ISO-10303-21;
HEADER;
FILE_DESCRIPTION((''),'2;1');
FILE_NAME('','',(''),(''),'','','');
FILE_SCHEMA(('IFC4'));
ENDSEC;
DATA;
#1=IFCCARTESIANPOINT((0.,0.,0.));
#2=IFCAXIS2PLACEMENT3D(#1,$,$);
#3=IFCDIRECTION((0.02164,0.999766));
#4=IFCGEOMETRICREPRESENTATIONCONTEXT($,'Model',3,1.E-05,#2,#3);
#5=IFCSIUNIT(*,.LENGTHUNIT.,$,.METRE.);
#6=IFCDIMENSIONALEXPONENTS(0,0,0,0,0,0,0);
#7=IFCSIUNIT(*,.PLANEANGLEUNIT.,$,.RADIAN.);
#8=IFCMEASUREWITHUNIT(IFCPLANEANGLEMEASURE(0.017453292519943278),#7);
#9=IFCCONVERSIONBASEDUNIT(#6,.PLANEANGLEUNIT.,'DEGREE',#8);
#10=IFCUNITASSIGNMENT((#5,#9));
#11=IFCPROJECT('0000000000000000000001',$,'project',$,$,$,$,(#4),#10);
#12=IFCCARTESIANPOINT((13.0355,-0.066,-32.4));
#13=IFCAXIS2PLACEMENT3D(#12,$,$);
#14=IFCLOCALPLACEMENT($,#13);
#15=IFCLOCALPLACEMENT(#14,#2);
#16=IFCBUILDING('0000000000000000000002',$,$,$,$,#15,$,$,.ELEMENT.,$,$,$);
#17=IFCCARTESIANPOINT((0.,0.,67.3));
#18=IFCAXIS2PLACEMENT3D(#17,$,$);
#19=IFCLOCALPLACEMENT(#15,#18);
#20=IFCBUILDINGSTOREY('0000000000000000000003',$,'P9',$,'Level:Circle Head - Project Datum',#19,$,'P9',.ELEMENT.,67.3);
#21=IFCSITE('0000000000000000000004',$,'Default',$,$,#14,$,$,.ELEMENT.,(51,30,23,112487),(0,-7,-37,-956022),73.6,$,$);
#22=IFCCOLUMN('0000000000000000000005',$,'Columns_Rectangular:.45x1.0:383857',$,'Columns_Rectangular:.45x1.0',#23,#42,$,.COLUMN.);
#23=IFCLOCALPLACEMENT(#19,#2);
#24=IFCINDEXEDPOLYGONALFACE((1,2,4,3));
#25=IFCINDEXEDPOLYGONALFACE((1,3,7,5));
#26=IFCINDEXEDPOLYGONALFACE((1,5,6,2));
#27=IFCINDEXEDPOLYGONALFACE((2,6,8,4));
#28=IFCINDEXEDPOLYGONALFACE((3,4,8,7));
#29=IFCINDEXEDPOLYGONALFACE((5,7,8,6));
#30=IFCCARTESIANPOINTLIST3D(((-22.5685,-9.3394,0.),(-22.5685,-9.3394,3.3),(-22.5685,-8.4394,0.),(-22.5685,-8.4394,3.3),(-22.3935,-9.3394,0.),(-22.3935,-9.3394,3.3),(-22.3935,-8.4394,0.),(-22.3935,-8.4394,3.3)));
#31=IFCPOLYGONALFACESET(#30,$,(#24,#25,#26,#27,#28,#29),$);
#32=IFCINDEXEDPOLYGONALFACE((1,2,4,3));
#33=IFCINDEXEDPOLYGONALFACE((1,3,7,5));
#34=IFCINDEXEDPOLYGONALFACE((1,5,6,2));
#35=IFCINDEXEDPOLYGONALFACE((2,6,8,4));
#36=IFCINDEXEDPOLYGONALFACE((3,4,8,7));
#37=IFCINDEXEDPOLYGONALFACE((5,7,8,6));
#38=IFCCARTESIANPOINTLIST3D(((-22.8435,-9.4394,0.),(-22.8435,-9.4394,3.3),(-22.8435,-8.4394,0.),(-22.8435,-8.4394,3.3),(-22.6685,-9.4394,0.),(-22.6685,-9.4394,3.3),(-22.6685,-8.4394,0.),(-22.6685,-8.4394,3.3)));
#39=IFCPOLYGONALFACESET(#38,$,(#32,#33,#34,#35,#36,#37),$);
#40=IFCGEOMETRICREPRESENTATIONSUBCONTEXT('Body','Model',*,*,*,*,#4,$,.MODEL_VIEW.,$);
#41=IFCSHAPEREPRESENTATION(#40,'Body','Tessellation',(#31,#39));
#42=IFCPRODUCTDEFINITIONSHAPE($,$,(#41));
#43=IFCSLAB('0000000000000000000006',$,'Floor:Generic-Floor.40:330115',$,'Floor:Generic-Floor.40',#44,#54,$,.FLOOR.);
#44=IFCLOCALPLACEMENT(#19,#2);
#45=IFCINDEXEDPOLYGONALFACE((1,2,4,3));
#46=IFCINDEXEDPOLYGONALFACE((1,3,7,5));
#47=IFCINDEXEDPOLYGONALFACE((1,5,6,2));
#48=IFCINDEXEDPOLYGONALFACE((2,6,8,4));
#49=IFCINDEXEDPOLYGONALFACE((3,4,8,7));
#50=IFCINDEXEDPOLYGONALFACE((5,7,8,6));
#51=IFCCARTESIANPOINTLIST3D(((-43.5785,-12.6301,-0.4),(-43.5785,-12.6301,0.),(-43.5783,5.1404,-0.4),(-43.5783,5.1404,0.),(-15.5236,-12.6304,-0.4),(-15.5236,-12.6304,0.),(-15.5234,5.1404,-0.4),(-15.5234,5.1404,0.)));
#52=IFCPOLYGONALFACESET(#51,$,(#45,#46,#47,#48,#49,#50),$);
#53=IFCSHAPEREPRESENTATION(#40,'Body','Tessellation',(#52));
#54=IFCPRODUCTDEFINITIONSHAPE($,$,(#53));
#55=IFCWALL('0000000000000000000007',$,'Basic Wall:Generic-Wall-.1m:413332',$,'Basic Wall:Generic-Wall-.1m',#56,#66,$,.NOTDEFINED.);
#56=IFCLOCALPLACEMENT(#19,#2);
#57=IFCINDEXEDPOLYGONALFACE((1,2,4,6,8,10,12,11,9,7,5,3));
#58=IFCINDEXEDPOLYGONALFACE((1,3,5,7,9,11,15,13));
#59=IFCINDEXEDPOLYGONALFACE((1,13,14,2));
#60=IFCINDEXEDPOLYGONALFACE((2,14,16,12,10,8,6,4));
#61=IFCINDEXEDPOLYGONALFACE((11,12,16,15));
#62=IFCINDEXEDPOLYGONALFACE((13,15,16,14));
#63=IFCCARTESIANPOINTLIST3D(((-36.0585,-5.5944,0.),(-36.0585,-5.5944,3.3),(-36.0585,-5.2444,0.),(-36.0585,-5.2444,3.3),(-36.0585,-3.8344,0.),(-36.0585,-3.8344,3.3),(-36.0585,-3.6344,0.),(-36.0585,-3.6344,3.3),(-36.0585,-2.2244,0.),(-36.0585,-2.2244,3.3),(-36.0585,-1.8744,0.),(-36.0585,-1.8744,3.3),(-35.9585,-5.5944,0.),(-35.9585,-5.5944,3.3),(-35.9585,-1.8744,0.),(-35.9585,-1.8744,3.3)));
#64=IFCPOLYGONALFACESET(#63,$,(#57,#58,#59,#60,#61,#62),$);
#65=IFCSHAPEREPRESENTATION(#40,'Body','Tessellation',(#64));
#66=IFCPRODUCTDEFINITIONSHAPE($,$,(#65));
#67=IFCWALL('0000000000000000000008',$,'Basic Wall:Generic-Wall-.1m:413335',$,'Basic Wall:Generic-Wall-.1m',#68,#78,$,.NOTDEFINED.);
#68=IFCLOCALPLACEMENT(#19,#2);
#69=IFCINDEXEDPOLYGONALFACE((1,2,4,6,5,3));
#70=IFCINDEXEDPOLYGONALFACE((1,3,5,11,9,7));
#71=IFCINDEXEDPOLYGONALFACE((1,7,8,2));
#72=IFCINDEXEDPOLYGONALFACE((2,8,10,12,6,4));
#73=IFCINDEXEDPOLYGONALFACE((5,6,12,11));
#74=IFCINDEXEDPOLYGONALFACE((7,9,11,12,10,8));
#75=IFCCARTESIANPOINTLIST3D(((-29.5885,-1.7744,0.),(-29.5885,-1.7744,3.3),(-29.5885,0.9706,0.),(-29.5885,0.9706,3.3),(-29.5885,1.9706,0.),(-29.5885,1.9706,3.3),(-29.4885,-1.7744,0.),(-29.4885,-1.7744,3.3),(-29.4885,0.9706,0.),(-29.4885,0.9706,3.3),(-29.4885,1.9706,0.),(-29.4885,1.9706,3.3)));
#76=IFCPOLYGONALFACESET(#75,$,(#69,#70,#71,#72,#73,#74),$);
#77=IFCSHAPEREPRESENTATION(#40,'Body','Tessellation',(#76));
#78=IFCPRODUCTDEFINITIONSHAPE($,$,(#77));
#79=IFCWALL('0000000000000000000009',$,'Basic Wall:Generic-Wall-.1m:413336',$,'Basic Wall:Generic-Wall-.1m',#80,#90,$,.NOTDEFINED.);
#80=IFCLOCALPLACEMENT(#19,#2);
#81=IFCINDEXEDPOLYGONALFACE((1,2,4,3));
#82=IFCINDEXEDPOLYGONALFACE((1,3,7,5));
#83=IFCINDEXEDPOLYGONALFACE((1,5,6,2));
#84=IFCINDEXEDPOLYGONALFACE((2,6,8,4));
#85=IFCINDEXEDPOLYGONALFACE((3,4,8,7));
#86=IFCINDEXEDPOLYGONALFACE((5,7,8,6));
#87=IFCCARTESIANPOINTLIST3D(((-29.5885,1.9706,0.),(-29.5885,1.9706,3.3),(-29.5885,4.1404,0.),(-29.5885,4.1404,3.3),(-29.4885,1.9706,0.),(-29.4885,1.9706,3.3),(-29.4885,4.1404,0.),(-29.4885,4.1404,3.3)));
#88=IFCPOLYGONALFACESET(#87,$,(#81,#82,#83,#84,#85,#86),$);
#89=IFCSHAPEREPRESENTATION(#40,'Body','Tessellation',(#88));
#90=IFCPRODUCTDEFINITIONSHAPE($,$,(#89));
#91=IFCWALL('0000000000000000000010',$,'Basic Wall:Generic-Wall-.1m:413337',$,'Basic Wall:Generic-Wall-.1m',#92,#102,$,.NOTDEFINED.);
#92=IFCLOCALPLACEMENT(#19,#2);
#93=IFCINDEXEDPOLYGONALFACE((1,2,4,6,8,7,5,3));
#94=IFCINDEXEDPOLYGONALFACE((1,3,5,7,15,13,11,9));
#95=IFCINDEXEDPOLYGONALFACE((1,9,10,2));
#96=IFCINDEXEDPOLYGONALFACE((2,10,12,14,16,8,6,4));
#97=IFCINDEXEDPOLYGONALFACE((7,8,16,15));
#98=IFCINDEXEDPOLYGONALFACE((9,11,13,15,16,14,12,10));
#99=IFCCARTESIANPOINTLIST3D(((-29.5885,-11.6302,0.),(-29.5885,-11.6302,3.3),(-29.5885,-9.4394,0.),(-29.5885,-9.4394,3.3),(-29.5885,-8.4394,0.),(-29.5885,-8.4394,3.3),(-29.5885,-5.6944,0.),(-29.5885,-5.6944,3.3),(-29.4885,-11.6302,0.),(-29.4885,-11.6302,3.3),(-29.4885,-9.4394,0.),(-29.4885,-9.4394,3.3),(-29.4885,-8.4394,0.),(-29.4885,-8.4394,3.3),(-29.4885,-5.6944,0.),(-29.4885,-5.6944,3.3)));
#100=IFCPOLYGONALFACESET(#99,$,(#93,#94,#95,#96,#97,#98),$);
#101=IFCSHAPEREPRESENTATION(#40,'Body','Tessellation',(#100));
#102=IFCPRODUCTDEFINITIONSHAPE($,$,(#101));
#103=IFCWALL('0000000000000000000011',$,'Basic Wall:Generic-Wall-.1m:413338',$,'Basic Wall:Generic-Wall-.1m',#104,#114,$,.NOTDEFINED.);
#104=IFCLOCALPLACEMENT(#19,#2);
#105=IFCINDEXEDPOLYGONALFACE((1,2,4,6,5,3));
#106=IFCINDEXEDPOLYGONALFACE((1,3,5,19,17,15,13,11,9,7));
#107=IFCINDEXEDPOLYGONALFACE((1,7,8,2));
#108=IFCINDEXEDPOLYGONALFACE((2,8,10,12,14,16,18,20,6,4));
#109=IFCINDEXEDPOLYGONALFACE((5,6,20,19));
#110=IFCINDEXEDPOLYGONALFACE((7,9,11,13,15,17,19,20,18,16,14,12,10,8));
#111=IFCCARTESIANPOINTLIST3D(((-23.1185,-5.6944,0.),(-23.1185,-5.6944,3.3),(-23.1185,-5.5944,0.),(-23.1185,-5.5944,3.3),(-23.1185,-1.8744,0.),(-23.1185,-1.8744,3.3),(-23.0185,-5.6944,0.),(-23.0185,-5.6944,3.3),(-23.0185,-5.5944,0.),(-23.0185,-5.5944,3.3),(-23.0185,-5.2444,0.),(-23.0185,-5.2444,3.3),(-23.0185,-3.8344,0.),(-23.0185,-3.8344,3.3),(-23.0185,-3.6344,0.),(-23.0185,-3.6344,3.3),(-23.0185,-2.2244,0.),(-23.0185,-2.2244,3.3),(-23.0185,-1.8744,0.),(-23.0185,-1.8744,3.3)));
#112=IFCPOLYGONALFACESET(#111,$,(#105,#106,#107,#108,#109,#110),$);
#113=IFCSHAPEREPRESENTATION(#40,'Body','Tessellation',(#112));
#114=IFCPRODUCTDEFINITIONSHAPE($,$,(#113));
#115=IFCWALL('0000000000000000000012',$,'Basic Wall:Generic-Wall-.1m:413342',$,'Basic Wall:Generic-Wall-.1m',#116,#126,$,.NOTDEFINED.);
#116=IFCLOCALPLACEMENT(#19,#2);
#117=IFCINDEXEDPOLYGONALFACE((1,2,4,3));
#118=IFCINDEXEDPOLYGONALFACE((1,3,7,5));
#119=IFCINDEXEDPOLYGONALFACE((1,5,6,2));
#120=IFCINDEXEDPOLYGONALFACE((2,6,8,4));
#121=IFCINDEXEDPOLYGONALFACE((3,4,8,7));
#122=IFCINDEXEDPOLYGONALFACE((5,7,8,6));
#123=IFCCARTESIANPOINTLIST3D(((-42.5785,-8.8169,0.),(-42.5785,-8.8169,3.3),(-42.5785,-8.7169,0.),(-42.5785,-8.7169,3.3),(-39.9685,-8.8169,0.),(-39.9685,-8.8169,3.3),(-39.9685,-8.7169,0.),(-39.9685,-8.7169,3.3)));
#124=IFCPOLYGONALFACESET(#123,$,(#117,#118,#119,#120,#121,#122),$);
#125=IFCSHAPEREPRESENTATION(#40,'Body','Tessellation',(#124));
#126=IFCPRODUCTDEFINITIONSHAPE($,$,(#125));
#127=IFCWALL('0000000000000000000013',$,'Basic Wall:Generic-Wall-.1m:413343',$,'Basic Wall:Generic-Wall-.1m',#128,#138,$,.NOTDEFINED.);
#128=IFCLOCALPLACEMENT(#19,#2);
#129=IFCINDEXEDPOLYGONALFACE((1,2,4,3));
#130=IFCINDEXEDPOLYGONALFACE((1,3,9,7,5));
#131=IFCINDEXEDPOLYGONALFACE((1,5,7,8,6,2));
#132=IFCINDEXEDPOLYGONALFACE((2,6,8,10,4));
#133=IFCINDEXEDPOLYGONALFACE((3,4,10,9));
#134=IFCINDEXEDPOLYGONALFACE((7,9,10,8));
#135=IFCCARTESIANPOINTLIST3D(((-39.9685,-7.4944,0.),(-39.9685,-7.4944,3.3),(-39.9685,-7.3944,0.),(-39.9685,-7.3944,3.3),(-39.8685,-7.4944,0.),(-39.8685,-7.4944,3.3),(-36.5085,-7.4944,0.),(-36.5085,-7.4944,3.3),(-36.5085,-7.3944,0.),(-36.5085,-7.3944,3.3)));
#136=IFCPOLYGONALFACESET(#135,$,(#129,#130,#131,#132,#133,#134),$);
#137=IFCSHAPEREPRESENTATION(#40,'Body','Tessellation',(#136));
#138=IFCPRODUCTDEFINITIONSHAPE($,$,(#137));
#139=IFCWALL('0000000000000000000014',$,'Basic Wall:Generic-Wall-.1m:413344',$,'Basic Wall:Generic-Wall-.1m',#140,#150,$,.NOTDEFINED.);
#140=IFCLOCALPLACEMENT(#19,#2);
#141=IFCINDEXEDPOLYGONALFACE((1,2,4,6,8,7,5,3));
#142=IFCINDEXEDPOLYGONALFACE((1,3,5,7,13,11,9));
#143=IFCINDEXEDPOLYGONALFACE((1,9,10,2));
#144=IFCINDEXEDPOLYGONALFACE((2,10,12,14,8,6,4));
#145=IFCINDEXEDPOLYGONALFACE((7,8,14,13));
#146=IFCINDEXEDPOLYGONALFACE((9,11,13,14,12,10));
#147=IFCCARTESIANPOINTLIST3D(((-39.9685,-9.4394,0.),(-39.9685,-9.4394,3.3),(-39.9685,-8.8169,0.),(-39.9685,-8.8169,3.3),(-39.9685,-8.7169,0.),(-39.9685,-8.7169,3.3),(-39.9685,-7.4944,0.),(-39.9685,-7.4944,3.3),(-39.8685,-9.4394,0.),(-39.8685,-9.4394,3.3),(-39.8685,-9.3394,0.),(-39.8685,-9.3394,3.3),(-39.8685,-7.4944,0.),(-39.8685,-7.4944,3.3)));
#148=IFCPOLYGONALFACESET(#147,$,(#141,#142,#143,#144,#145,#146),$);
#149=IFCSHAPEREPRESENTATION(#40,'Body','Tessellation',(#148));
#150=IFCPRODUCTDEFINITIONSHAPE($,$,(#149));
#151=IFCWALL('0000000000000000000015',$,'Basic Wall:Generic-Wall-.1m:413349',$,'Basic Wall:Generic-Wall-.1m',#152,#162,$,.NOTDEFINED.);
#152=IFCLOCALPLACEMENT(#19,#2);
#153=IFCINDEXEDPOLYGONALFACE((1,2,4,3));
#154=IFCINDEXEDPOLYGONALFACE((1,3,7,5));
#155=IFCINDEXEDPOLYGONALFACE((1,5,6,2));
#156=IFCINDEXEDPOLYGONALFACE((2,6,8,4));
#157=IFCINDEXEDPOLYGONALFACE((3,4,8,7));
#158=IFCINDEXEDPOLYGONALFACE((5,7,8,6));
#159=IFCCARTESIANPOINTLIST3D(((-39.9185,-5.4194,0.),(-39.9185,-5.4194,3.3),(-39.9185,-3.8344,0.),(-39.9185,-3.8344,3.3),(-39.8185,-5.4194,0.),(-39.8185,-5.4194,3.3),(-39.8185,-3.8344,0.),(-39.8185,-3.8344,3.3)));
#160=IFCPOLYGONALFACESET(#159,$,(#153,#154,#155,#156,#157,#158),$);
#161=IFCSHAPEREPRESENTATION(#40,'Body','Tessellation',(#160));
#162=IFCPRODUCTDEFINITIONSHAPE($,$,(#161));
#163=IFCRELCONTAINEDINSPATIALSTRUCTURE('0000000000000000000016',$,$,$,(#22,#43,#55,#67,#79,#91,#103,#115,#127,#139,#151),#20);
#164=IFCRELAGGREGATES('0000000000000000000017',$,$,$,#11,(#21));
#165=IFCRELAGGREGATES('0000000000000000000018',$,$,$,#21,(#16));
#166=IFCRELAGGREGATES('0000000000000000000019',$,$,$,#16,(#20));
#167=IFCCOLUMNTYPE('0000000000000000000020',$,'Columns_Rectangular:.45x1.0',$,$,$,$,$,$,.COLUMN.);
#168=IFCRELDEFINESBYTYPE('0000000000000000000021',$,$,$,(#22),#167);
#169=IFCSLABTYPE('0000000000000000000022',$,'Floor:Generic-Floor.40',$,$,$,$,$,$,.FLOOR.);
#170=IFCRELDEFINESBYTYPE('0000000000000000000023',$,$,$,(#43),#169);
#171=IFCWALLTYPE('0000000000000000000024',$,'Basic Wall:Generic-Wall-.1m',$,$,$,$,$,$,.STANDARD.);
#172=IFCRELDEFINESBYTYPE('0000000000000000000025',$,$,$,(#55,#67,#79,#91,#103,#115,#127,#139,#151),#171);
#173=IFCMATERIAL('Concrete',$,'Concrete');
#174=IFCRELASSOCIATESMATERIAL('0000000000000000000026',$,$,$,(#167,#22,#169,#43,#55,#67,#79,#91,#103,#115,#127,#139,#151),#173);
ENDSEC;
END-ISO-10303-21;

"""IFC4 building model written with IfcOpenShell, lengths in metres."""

from ifc_helpers import new_model, entity, si_unit, converted_unit, direction, frame, origin, place, context, subcontext, project, spatial, indexed_curve, outline, extrude, source, transform, mapped, material, type_object, type_shapes, element, save


model = new_model("IFC4")

# Units and contexts
model_context = context("Model", 3, precision=1e-05, world=origin(), true_north=direction((0.02164, 0.999766)))
body_context = subcontext(model_context, "Body", "Model", "MODEL_VIEW")
ifc_project = project(units=[si_unit("LENGTHUNIT", "METRE"), converted_unit("PLANEANGLEUNIT", "DEGREE", entity("IfcPlaneAngleMeasure", 0.017453292519943278), si_unit("PLANEANGLEUNIT", "RADIAN"), dimensions=[0, 0, 0, 0, 0, 0, 0])], contexts=[model_context])

# Site, building, storey
site_placement = place(None, frame((13.0355, -0.066, -32.4)))
site = spatial("IfcSite", under=ifc_project, at=site_placement, Name="Default", CompositionType="ELEMENT", RefLatitude=(51, 30, 23, 112487), RefLongitude=(0, -7, -37, -956022), RefElevation=73.6)
building_placement = place(site_placement, origin())
building = spatial("IfcBuilding", under=site, at=building_placement, CompositionType="ELEMENT")
storey_placement = place(building_placement, frame((0.0, 0.0, 67.3)))
storey = spatial("IfcBuildingStorey", under=building, at=storey_placement, Name="P9", ObjectType="Level:Circle Head - Project Datum", LongName="P9", CompositionType="ELEMENT", Elevation=67.3)

# Column
ifc_material = material(Name="Concrete", Category="Concrete")
column_type = type_object("IfcColumnType", Name="Columns_Rectangular:.45x1.0", PredefinedType="COLUMN", material=ifc_material)
shared_shape = source(origin(), body_context, "Body", "SweptSolid", [
    extrude(outline(indexed_curve([(-0.45, -0.0875), (0.45, -0.0875), (0.45, 0.0875), (-0.45, 0.0875), (-0.45, -0.0875)], self_intersect=False)), frame((-22.481, -8.8894, 67.3), z_axis=(0.0, 0.0, 1.0), x_axis=(0.0, -1.0, 0.0)), (0.0, 0.0, 1.0), 3.3),
    extrude(outline(indexed_curve([(-0.0875, -0.5), (0.0875, -0.5), (0.0875, 0.5), (-0.0875, 0.5), (-0.0875, -0.5)], self_intersect=False)), frame((-22.756, -8.9394, 67.3)), (0.0, 0.0, 1.0), 3.3),
])
type_shapes(column_type, [shared_shape])
column_placement = place(storey_placement, frame((0.0, 0.0, -67.3)))
element("IfcColumn", 1, at=column_placement, inside=storey, type_object=column_type, material=ifc_material, Name="Columns_Rectangular:.45x1.0:383857", ObjectType="Columns_Rectangular:.45x1.0", PredefinedType="COLUMN", context=body_context, shape_type="MappedRepresentation", body=[
    mapped(shared_shape, transform((0.0, 0.0, 0.0), scale=1.0)),
])

# Slab
slab_type = type_object("IfcSlabType", Name="Floor:Generic-Floor.40", PredefinedType="FLOOR", material=ifc_material)
slab_placement = place(storey_placement, origin())
element("IfcSlab", 2, at=slab_placement, inside=storey, type_object=slab_type, material=ifc_material, Name="Floor:Generic-Floor.40:330115", ObjectType="Floor:Generic-Floor.40", PredefinedType="FLOOR", context=body_context, shape_type="SweptSolid", body=[
    extrude(outline(indexed_curve([(-14.0274, -8.8853), (14.0275, -8.8853), (14.0274, 8.8855), (-14.0275, 8.8852), (-14.0274, -8.8853)], self_intersect=False)), frame((-29.5509, -3.7449, 0.0), z_axis=(0.0, 0.0, -1.0), x_axis=(1.0, 0.0, 0.0)), (0.0, 0.0, 1.0), 0.4),
])

# Walls
wall_type_1 = type_object("IfcWallType", Name="Basic Wall:Generic-Wall-.1m", PredefinedType="STANDARD")
wall_1_placement = place(storey_placement, frame((-36.0085, -1.8744, 0.0), z_axis=(0.0, 0.0, 1.0), x_axis=(0.0, -1.0, 0.0)))
element("IfcWall", 3, at=wall_1_placement, inside=storey, type_object=wall_type_1, material=ifc_material, Name="Basic Wall:Generic-Wall-.1m:413332", ObjectType="Basic Wall:Generic-Wall-.1m", PredefinedType="NOTDEFINED", context=body_context, shape_type="SweptSolid", body=[
    extrude(outline(indexed_curve([(3.72, -0.05), (3.72, 0.05), (0.0, 0.05), (0.0, -0.05), (0.35, -0.05), (1.76, -0.05), (1.96, -0.05), (3.37, -0.05), (3.72, -0.05)], self_intersect=False)), origin(), (0.0, 0.0, 1.0), 3.3),
])
wall_2_placement = place(storey_placement, frame((-29.5385, 1.9706, 0.0), z_axis=(0.0, 0.0, 1.0), x_axis=(0.0, -1.0, 0.0)))
element("IfcWall", 4, at=wall_2_placement, inside=storey, type_object=wall_type_1, material=ifc_material, Name="Basic Wall:Generic-Wall-.1m:413335", ObjectType="Basic Wall:Generic-Wall-.1m", PredefinedType="NOTDEFINED", context=body_context, shape_type="SweptSolid", body=[
    extrude(outline(indexed_curve([(3.745, -0.05), (3.745, 0.05), (1.0, 0.05), (0.0, 0.05), (0.0, -0.05), (1.0, -0.05), (3.745, -0.05)], self_intersect=False)), origin(), (0.0, 0.0, 1.0), 3.3),
])
wall_3_placement = place(storey_placement, frame((-29.5385, 1.9706, 0.0), z_axis=(0.0, 0.0, 1.0), x_axis=(0.0, 1.0, 0.0)))
element("IfcWall", 5, at=wall_3_placement, inside=storey, type_object=wall_type_1, material=ifc_material, Name="Basic Wall:Generic-Wall-.1m:413336", ObjectType="Basic Wall:Generic-Wall-.1m", PredefinedType="NOTDEFINED", context=body_context, shape_type="SweptSolid", body=[
    extrude(outline(indexed_curve([(2.1699, -0.05), (2.1699, 0.05), (0.0, 0.05), (0.0, -0.05), (2.1699, -0.05)], self_intersect=False)), origin(), (0.0, 0.0, 1.0), 3.3),
])
wall_4_placement = place(storey_placement, frame((-29.5385, -5.6944, 0.0), z_axis=(0.0, 0.0, 1.0), x_axis=(0.0, -1.0, 0.0)))
element("IfcWall", 6, at=wall_4_placement, inside=storey, type_object=wall_type_1, material=ifc_material, Name="Basic Wall:Generic-Wall-.1m:413337", ObjectType="Basic Wall:Generic-Wall-.1m", PredefinedType="NOTDEFINED", context=body_context, shape_type="SweptSolid", body=[
    extrude(outline(indexed_curve([(5.9358, -0.05), (5.9358, 0.05), (3.745, 0.05), (2.745, 0.05), (0.0, 0.05), (0.0, -0.05), (2.745, -0.05), (3.745, -0.05), (5.9358, -0.05)], self_intersect=False)), origin(), (0.0, 0.0, 1.0), 3.3),
])
wall_5_placement = place(storey_placement, frame((-23.0685, -1.8744, 0.0), z_axis=(0.0, 0.0, 1.0), x_axis=(0.0, -1.0, 0.0)))
element("IfcWall", 7, at=wall_5_placement, inside=storey, type_object=wall_type_1, material=ifc_material, Name="Basic Wall:Generic-Wall-.1m:413338", ObjectType="Basic Wall:Generic-Wall-.1m", PredefinedType="NOTDEFINED", context=body_context, shape_type="SweptSolid", body=[
    extrude(outline(indexed_curve([(3.82, -0.05), (3.82, 0.05), (3.72, 0.05), (3.37, 0.05), (1.96, 0.05), (1.76, 0.05), (0.35, 0.05), (0.0, 0.05), (0.0, -0.05), (3.72, -0.05), (3.82, -0.05)], self_intersect=False)), origin(), (0.0, 0.0, 1.0), 3.3),
])
wall_6_placement = place(storey_placement, frame((-39.9685, -8.7669, 0.0), z_axis=(0.0, 0.0, 1.0), x_axis=(-1.0, 0.0, 0.0)))
element("IfcWall", 8, at=wall_6_placement, inside=storey, type_object=wall_type_1, material=ifc_material, Name="Basic Wall:Generic-Wall-.1m:413342", ObjectType="Basic Wall:Generic-Wall-.1m", PredefinedType="NOTDEFINED", context=body_context, shape_type="SweptSolid", body=[
    extrude(outline(indexed_curve([(2.61, -0.05), (2.61, 0.05), (0.0, 0.05), (0.0, -0.05), (2.61, -0.05)], self_intersect=False)), origin(), (0.0, 0.0, 1.0), 3.3),
])
wall_7_placement = place(storey_placement, frame((-36.5085, -7.4444, 0.0), z_axis=(0.0, 0.0, 1.0), x_axis=(-1.0, 0.0, 0.0)))
element("IfcWall", 9, at=wall_7_placement, inside=storey, type_object=wall_type_1, material=ifc_material, Name="Basic Wall:Generic-Wall-.1m:413343", ObjectType="Basic Wall:Generic-Wall-.1m", PredefinedType="NOTDEFINED", context=body_context, shape_type="SweptSolid", body=[
    extrude(outline(indexed_curve([(3.46, -0.05), (3.46, 0.05), (3.36, 0.05), (0.0, 0.05), (0.0, -0.05), (3.46, -0.05)], self_intersect=False)), origin(), (0.0, 0.0, 1.0), 3.3),
])
wall_8_placement = place(storey_placement, frame((-39.9185, -7.4944, 0.0), z_axis=(0.0, 0.0, 1.0), x_axis=(0.0, -1.0, 0.0)))
element("IfcWall", 10, at=wall_8_placement, inside=storey, type_object=wall_type_1, material=ifc_material, Name="Basic Wall:Generic-Wall-.1m:413344", ObjectType="Basic Wall:Generic-Wall-.1m", PredefinedType="NOTDEFINED", context=body_context, shape_type="SweptSolid", body=[
    extrude(outline(indexed_curve([(1.945, -0.05), (1.945, 0.05), (1.845, 0.05), (0.0, 0.05), (0.0, -0.05), (1.2225, -0.05), (1.3225, -0.05), (1.945, -0.05)], self_intersect=False)), origin(), (0.0, 0.0, 1.0), 3.3),
])
wall_9_placement = place(storey_placement, frame((-39.8685, -5.4194, 0.0), z_axis=(0.0, 0.0, 1.0), x_axis=(0.0, 1.0, 0.0)))
element("IfcWall", 11, at=wall_9_placement, inside=storey, type_object=wall_type_1, material=ifc_material, Name="Basic Wall:Generic-Wall-.1m:413349", ObjectType="Basic Wall:Generic-Wall-.1m", PredefinedType="NOTDEFINED", context=body_context, shape_type="SweptSolid", body=[
    extrude(outline(indexed_curve([(1.585, -0.05), (1.585, 0.05), (0.0, 0.05), (0.0, -0.05), (1.585, -0.05)], self_intersect=False)), origin(), (0.0, 0.0, 1.0), 3.3),
])

save(model, "model.ifc")
